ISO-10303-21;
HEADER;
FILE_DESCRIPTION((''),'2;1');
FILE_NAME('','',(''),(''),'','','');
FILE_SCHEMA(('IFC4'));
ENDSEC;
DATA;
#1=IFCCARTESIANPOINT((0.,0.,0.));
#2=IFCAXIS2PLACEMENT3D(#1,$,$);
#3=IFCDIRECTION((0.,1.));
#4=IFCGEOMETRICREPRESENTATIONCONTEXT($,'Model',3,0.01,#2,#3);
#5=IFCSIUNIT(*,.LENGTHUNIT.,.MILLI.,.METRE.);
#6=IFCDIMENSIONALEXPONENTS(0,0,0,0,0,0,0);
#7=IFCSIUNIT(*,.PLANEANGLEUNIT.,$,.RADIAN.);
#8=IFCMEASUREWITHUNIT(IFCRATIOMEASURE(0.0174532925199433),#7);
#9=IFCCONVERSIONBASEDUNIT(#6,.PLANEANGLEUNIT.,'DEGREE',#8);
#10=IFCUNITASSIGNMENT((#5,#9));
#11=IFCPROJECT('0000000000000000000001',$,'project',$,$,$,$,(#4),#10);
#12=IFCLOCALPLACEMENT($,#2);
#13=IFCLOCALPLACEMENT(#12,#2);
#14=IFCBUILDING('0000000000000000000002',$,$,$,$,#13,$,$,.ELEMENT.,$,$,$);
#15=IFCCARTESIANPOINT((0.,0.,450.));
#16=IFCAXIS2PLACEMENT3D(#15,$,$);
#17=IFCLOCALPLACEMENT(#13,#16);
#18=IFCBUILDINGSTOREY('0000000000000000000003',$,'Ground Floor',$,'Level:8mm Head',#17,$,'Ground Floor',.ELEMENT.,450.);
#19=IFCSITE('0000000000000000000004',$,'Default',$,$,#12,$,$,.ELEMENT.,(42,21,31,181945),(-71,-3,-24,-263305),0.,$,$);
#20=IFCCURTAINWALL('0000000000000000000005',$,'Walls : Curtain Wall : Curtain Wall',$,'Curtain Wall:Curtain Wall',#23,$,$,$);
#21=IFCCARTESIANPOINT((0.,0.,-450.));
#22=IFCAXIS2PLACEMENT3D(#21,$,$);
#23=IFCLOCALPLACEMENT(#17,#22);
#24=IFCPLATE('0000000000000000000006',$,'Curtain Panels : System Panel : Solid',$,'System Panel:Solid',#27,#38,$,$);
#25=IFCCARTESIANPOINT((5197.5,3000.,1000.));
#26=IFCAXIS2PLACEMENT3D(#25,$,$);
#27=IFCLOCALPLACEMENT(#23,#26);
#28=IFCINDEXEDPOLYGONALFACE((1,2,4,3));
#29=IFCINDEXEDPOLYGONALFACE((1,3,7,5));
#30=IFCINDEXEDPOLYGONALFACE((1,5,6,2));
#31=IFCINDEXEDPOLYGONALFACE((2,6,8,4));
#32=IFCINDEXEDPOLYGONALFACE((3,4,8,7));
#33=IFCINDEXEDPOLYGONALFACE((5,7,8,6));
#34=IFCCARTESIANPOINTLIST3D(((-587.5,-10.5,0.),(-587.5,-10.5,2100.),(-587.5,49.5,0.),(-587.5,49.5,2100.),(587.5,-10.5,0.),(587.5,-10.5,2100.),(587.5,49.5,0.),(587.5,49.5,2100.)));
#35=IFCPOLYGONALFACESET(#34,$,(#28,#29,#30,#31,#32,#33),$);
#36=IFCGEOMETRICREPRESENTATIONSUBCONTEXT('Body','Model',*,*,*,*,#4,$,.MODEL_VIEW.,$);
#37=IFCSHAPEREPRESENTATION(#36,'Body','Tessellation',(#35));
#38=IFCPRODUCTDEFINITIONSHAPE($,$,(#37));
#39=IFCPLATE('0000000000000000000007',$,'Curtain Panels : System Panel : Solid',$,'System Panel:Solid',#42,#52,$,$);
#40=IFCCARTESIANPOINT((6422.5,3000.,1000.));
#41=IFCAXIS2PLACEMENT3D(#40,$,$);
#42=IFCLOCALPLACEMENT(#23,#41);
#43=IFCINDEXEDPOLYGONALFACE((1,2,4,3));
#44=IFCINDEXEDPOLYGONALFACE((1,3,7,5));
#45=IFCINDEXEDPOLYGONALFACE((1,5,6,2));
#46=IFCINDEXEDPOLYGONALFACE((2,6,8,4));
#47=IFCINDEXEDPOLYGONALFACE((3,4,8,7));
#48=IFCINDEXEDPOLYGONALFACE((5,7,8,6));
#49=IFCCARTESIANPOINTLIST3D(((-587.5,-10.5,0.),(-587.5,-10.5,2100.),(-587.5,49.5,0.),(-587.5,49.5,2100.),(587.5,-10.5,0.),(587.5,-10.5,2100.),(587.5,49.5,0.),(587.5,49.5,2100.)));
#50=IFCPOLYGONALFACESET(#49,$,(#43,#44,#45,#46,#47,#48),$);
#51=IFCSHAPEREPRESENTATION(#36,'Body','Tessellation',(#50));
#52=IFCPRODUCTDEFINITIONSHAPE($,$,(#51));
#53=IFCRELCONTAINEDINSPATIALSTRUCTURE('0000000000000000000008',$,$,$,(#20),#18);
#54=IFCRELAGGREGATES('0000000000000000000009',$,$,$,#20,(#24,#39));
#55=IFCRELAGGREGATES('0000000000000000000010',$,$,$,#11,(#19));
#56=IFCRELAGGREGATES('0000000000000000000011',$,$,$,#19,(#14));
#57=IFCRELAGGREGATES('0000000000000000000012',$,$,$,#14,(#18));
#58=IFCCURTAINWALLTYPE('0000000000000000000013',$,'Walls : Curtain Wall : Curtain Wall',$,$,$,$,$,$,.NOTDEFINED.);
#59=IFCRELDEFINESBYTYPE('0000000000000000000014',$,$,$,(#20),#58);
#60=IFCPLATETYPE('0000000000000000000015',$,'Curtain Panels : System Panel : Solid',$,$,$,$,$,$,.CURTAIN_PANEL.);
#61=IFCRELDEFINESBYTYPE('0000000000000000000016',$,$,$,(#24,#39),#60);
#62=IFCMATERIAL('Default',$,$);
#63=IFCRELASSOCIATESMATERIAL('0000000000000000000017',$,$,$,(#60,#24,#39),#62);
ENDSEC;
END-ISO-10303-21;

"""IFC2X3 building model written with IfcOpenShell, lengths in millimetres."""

from ifc_helpers import new_model, entity, si_unit, converted_unit, direction, frame, origin, origin_2d_with_axis, place, context, subcontext, project, spatial, rectangle, extrude, source, transform, mapped, material, type_object, type_shapes, element, aggregate, save


model = new_model("IFC2X3")

# Units and contexts
model_context = context("Model", 3, precision=0.01, world=origin(), true_north=direction((0.0, 1.0)))
body_context = subcontext(model_context, "Body", "Model", "MODEL_VIEW")
ifc_project = project(units=[si_unit("LENGTHUNIT", "METRE", prefix="MILLI"), converted_unit("PLANEANGLEUNIT", "DEGREE", entity("IfcRatioMeasure", 0.0174532925199433), si_unit("PLANEANGLEUNIT", "RADIAN"), dimensions=[0, 0, 0, 0, 0, 0, 0])], contexts=[model_context])

# Site, building, storey
site_placement = place(None, origin())
site = spatial("IfcSite", under=ifc_project, at=site_placement, Name="Default", CompositionType="ELEMENT", RefLatitude=(42, 21, 31, 181945), RefLongitude=(-71, -3, -24, -263305), RefElevation=0.0)
building_placement = place(site_placement, origin())
building = spatial("IfcBuilding", under=site, at=building_placement, CompositionType="ELEMENT")
storey_placement = place(building_placement, frame((0.0, 0.0, 450.0)))
storey = spatial("IfcBuildingStorey", under=building, at=storey_placement, Name="Ground Floor", ObjectType="Level:8mm Head", LongName="Ground Floor", CompositionType="ELEMENT", Elevation=450.0)

# Curtain wall, plates
curtain_wall_type = type_object("IfcCurtainWallType", Name="Walls : Curtain Wall : Curtain Wall", PredefinedType="NOTDEFINED")
curtain_wall_placement = place(storey_placement, frame((0.0, 0.0, -450.0)))
curtain_wall = element("IfcCurtainWall", 1, at=curtain_wall_placement, inside=storey, type_object=curtain_wall_type, Name="Walls : Curtain Wall : Curtain Wall", ObjectType="Curtain Wall:Curtain Wall")
ifc_material_1 = material(Name="Default")
plate_type = type_object("IfcPlateType", Name="Curtain Panels : System Panel : Solid", PredefinedType="CURTAIN_PANEL", material=ifc_material_1)
shared_shape_1 = source(origin(), body_context, "Body", "SweptSolid", [
    extrude(rectangle(XDim=60.0, YDim=1175.0, at=origin_2d_with_axis()), frame((0.0, 19.5, 0.0), z_axis=(0.0, 0.0, 1.0), x_axis=(0.0, 1.0, 0.0)), (0.0, 0.0, 1.0), 2100.0),
])
type_shapes(plate_type, [shared_shape_1])
plate_1_placement = place(curtain_wall_placement, frame((5197.5, 3000.0, 1000.0)))
plate_1 = element("IfcPlate", 2, at=plate_1_placement, type_object=plate_type, material=ifc_material_1, Name="Curtain Panels : System Panel : Solid", ObjectType="System Panel:Solid", context=body_context, shape_type="MappedRepresentation", body=[
    mapped(shared_shape_1, transform((0.0, 0.0, 0.0), scale=1.0)),
])
plate_2_placement = place(curtain_wall_placement, frame((6422.5, 3000.0, 1000.0)))
plate_2 = element("IfcPlate", 3, at=plate_2_placement, type_object=plate_type, material=ifc_material_1, Name="Curtain Panels : System Panel : Solid", ObjectType="System Panel:Solid", context=body_context, shape_type="MappedRepresentation", body=[
    mapped(shared_shape_1, transform((0.0, 0.0, 0.0), scale=1.0)),
])
aggregate(curtain_wall, [plate_1, plate_2])

save(model, "model.ifc")
